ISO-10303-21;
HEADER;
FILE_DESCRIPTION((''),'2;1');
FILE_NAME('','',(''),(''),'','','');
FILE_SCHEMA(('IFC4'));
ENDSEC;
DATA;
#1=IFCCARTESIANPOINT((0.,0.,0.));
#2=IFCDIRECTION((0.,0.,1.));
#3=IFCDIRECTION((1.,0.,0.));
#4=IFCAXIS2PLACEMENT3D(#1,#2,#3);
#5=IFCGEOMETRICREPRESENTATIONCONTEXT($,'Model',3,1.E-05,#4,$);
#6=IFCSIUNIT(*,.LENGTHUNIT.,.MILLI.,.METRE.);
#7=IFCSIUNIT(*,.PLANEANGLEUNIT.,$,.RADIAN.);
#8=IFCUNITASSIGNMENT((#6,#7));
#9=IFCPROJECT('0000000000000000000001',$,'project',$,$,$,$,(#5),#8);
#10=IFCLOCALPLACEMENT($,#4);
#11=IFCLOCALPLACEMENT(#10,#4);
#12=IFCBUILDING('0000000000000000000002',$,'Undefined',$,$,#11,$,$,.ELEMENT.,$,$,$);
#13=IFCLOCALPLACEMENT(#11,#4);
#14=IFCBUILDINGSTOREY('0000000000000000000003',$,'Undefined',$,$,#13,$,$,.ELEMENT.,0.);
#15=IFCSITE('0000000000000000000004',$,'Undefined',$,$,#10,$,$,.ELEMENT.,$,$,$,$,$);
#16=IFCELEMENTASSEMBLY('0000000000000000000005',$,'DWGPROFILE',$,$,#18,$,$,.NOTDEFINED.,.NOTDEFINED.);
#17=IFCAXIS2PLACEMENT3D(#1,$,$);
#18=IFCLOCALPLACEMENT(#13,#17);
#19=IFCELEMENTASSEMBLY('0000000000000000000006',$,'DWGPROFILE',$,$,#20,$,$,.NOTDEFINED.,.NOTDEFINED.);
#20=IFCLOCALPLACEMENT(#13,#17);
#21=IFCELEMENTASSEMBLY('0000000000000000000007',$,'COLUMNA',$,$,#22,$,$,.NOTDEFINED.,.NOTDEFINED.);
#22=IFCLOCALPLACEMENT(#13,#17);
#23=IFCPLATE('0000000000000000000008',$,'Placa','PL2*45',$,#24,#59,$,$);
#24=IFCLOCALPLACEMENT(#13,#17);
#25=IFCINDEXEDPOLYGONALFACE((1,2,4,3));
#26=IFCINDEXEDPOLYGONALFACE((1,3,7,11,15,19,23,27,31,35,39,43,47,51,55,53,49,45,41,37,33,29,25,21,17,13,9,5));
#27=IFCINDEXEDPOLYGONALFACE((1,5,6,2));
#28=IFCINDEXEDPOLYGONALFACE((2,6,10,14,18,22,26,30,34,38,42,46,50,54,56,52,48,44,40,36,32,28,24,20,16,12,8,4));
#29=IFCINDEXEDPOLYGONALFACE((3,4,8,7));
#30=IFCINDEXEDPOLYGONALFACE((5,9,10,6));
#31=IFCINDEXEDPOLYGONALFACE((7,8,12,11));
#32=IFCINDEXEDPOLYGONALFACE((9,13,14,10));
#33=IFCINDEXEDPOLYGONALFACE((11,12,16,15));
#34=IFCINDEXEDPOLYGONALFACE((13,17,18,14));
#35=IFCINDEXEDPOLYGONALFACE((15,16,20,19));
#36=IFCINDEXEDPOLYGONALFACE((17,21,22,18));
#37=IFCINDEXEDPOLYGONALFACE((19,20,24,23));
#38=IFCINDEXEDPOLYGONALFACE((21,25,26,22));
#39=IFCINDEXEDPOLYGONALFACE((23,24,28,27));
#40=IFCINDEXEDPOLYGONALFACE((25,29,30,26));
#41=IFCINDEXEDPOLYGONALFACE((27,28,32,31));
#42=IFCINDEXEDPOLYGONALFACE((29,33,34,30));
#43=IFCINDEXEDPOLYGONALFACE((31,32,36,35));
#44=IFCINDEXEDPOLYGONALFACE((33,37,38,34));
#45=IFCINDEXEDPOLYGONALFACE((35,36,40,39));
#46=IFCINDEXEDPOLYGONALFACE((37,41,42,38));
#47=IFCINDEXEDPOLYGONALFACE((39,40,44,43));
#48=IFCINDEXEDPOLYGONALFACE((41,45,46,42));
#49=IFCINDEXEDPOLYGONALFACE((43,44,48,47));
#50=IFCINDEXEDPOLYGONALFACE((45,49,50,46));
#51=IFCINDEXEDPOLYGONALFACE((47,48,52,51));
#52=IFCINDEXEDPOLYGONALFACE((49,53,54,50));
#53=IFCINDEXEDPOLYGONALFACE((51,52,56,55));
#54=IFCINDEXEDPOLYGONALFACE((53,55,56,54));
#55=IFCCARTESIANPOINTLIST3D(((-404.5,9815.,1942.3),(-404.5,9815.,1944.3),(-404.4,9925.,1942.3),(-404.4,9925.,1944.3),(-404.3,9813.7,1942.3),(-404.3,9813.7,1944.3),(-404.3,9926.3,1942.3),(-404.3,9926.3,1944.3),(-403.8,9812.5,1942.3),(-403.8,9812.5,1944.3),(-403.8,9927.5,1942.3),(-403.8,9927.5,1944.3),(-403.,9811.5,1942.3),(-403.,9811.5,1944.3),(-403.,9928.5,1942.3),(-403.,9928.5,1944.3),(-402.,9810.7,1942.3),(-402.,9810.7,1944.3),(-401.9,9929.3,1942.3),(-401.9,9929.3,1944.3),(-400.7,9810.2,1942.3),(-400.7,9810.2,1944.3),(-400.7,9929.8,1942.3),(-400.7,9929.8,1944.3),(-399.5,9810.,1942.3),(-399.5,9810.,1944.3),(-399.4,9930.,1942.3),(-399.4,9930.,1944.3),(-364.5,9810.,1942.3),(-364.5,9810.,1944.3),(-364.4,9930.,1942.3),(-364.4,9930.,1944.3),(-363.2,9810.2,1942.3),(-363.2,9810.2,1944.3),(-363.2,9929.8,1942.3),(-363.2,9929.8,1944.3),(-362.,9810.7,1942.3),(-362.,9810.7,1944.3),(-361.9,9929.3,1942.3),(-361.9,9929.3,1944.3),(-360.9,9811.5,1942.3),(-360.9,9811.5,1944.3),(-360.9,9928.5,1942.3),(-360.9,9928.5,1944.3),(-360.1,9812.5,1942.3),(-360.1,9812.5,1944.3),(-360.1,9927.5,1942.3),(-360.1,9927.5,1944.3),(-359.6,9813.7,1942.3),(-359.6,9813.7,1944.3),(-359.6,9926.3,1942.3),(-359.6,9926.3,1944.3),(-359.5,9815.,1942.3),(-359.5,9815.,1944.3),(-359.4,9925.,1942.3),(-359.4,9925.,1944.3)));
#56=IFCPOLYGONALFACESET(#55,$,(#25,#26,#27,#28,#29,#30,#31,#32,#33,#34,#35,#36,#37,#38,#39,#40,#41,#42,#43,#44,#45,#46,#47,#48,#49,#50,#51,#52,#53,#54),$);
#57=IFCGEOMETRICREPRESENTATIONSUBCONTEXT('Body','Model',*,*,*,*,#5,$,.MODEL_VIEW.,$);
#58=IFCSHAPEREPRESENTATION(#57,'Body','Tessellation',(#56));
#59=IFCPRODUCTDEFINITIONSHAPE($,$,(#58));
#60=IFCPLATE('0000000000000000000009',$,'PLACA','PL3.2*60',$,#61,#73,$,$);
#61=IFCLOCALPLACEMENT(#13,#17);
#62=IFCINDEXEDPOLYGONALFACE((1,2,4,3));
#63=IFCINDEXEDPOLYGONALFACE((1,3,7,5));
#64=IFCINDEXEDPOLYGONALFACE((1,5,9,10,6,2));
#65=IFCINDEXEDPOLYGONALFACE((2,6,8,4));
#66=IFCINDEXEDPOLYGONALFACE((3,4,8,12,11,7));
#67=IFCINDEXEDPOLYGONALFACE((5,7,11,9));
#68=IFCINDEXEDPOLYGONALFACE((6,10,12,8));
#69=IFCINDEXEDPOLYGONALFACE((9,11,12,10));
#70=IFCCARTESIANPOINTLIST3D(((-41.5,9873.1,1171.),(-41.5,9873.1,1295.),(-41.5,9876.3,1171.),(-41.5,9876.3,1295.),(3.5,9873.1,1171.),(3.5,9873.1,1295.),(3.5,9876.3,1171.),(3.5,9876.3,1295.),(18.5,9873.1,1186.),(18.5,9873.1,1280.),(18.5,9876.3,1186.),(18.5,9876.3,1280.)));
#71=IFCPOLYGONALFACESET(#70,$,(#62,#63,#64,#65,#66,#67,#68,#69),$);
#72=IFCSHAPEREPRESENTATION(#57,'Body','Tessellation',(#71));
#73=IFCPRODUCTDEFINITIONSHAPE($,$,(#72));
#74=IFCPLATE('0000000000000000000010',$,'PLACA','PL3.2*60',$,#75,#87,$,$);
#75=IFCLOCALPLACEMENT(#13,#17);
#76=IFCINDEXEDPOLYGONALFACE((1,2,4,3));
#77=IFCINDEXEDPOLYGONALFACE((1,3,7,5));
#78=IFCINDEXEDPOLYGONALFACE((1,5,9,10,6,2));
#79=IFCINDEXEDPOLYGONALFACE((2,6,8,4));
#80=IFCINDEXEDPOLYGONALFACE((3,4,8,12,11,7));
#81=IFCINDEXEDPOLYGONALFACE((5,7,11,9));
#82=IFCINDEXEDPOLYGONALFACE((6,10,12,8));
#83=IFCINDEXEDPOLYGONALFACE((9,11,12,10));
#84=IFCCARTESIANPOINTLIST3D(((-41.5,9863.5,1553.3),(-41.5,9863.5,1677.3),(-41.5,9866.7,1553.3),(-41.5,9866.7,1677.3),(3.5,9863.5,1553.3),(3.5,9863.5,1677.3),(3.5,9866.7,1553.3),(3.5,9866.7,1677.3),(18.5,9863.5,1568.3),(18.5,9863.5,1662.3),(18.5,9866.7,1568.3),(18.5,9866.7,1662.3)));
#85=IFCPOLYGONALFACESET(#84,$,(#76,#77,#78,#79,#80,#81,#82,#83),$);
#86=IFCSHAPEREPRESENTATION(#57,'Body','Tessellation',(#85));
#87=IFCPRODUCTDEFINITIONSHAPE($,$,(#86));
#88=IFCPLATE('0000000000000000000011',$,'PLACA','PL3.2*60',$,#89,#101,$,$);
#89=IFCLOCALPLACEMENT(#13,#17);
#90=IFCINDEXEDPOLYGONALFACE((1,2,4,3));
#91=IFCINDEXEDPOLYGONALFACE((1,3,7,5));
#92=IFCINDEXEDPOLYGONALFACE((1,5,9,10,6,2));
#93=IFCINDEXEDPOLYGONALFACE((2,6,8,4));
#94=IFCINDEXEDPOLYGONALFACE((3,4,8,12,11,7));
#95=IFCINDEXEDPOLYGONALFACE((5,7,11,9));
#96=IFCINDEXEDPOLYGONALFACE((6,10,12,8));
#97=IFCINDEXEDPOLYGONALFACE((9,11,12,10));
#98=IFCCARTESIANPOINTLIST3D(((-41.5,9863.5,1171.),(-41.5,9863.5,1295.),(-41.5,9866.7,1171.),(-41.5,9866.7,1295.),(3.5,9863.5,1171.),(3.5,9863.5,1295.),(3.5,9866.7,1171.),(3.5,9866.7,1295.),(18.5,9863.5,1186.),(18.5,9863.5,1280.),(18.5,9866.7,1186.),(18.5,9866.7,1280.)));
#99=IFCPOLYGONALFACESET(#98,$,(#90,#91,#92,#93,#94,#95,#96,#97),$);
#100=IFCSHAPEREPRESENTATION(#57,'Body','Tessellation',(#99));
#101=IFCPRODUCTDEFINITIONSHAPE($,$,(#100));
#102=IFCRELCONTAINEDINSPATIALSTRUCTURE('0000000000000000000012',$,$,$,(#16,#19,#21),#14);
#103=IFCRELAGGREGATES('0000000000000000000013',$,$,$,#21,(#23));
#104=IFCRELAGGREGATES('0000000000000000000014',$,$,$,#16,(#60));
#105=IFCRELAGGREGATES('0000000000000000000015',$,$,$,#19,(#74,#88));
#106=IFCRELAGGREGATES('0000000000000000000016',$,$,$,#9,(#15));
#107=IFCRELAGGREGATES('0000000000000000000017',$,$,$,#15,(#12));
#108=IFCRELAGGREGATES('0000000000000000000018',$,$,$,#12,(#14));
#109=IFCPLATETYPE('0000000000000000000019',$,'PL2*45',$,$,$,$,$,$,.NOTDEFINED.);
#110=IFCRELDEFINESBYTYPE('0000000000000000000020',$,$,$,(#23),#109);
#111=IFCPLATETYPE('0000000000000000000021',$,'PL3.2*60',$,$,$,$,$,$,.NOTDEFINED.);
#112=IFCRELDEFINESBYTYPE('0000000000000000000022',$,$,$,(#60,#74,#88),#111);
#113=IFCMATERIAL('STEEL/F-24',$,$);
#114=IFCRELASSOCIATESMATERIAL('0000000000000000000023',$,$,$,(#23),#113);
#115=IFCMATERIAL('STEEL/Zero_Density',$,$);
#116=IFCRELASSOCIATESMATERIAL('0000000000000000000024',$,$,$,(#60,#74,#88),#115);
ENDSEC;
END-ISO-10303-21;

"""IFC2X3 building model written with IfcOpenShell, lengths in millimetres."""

from ifc_helpers import new_model, si_unit, frame, frame_2d, origin_with_axes, place, context, subcontext, project, spatial, polyline, circle_curve, parameter, trimmed, segment, composite_curve, outline, extrude, material, type_object, element, aggregate, save


model = new_model("IFC2X3")

# Units and contexts
model_context = context("Model", 3, precision=1e-05, world=origin_with_axes())
body_context = subcontext(model_context, "Body", "Model", "MODEL_VIEW")
ifc_project = project(units=[si_unit("LENGTHUNIT", "METRE", prefix="MILLI"), si_unit("PLANEANGLEUNIT", "RADIAN")], contexts=[model_context])

# Site, building, storey
site_placement = place(None, origin_with_axes())
site = spatial("IfcSite", under=ifc_project, at=site_placement, Name="Undefined", CompositionType="ELEMENT")
building_placement = place(site_placement, origin_with_axes())
building = spatial("IfcBuilding", under=site, at=building_placement, Name="Undefined", CompositionType="ELEMENT")
storey_placement = place(building_placement, origin_with_axes())
storey = spatial("IfcBuildingStorey", under=building, at=storey_placement, Name="Undefined", CompositionType="ELEMENT", Elevation=0.0)

# Element assembly
assembly_1_placement = place(storey_placement, origin_with_axes())
assembly_1 = element("IfcElementAssembly", 1, at=assembly_1_placement, inside=storey, Name="DWGPROFILE", AssemblyPlace="NOTDEFINED", PredefinedType="NOTDEFINED")
ifc_material_1 = material(Name="STEEL/Zero_Density")

# Element assembly
assembly_2_placement = place(storey_placement, origin_with_axes())
assembly_2 = element("IfcElementAssembly", 2, at=assembly_2_placement, inside=storey, Name="DWGPROFILE", AssemblyPlace="NOTDEFINED", PredefinedType="NOTDEFINED")

# Element assembly, plate
assembly_3_placement = place(storey_placement, origin_with_axes())
assembly_3 = element("IfcElementAssembly", 3, at=assembly_3_placement, inside=storey, Name="COLUMNA", AssemblyPlace="NOTDEFINED", PredefinedType="NOTDEFINED")
ifc_material_2 = material(Name="STEEL/F-24")
plate_type_1 = type_object("IfcPlateType", Name="PL2*45", PredefinedType="NOTDEFINED")
plate_1_placement = place(assembly_3_placement, frame((-404.4, 9930.0, 1943.3), z_axis=(0.000121, 0.000003, -1.0), x_axis=(1.0, 0.000071, 0.000121)))
plate_1 = element("IfcPlate", 4, at=plate_1_placement, type_object=plate_type_1, material=ifc_material_2, Name="Placa", Description="PL2*45", context=body_context, shape_type="SweptSolid", body=[
    extrude(outline(composite_curve([segment(trimmed(circle_curve(frame_2d((5.0, 5.0), x_axis=(-1.0, -0.000156)), 5.0), [parameter(0.0)], [parameter(1.57064)], True, "PARAMETER"), True, "CONTINUOUS"), segment(polyline([(5.0, 0.0), (40.0, 0.0)]), True, "CONTINUOUS"), segment(trimmed(circle_curve(frame_2d((40.0, 5.0), x_axis=(0.0, -1.0)), 5.0), [parameter(0.0)], [parameter(1.570952)], True, "PARAMETER"), True, "CONTINUOUS"), segment(polyline([(45.0, 5.0), (45.0, 115.0)]), True, "CONTINUOUS"), segment(trimmed(circle_curve(frame_2d((40.0, 115.0), x_axis=(1.0, 0.000156)), 5.0), [parameter(0.0)], [parameter(1.57071)], True, "PARAMETER"), True, "CONTINUOUS"), segment(polyline([(40.0, 120.0), (5.0, 120.0)]), True, "CONTINUOUS"), segment(trimmed(circle_curve(frame_2d((5.0, 115.0), x_axis=(-0.000069, 1.0)), 5.0), [parameter(0.0)], [parameter(1.570883)], True, "PARAMETER"), True, "CONTINUOUS"), segment(polyline([(0.0, 115.0), (0.0, 5.0)]), True, "CONTINUOUS")], self_intersect=True)), frame((0.0, 0.0, -1.0), z_axis=(0.0, 0.0, 1.0), x_axis=(1.0, 0.0, 0.0)), (0.0, 0.0, 1.0), 2.0),
])
aggregate(assembly_3, [plate_1])

# Plates
plate_type_2 = type_object("IfcPlateType", Name="PL3.2*60", PredefinedType="NOTDEFINED")
plate_2_placement = place(assembly_1_placement, frame((-41.5, 9874.7, 1171.0), z_axis=(0.0, -1.0, 0.0), x_axis=(1.0, 0.0, 0.0)))
plate_2 = element("IfcPlate", 5, at=plate_2_placement, type_object=plate_type_2, material=ifc_material_1, Name="PLACA", Description="PL3.2*60", context=body_context, shape_type="SweptSolid", body=[
    extrude(outline(polyline([(0.0, 0.0), (45.0, 0.0), (60.0, 15.0), (60.0, 109.0), (45.0, 124.0), (0.0, 124.0), (0.0, 0.0)])), frame((0.0, 0.0, -1.6), z_axis=(0.0, 0.0, 1.0), x_axis=(1.0, 0.0, 0.0)), (0.0, 0.0, 1.0), 3.2),
])
aggregate(assembly_1, [plate_2])
plate_3_placement = place(assembly_2_placement, frame((-41.5, 9865.1, 1553.3), z_axis=(0.0, -1.0, 0.0), x_axis=(1.0, 0.0, 0.0)))
plate_3 = element("IfcPlate", 6, at=plate_3_placement, type_object=plate_type_2, material=ifc_material_1, Name="PLACA", Description="PL3.2*60", context=body_context, shape_type="SweptSolid", body=[
    extrude(outline(polyline([(0.0, 0.0), (45.0, 0.0), (60.0, 15.0), (60.0, 109.0), (45.0, 124.0), (0.0, 124.0), (0.0, 0.0)])), frame((0.0, 0.0, -1.6), z_axis=(0.0, 0.0, 1.0), x_axis=(1.0, 0.0, 0.0)), (0.0, 0.0, 1.0), 3.2),
])
plate_4_placement = place(assembly_2_placement, frame((-41.5, 9865.1, 1171.0), z_axis=(0.0, -1.0, 0.0), x_axis=(1.0, 0.0, 0.0)))
plate_4 = element("IfcPlate", 7, at=plate_4_placement, type_object=plate_type_2, material=ifc_material_1, Name="PLACA", Description="PL3.2*60", context=body_context, shape_type="SweptSolid", body=[
    extrude(outline(polyline([(0.0, 0.0), (45.0, 0.0), (60.0, 15.0), (60.0, 109.0), (45.0, 124.0), (0.0, 124.0), (0.0, 0.0)])), frame((0.0, 0.0, -1.6), z_axis=(0.0, 0.0, 1.0), x_axis=(1.0, 0.0, 0.0)), (0.0, 0.0, 1.0), 3.2),
])
aggregate(assembly_2, [plate_3, plate_4])

save(model, "model.ifc")
